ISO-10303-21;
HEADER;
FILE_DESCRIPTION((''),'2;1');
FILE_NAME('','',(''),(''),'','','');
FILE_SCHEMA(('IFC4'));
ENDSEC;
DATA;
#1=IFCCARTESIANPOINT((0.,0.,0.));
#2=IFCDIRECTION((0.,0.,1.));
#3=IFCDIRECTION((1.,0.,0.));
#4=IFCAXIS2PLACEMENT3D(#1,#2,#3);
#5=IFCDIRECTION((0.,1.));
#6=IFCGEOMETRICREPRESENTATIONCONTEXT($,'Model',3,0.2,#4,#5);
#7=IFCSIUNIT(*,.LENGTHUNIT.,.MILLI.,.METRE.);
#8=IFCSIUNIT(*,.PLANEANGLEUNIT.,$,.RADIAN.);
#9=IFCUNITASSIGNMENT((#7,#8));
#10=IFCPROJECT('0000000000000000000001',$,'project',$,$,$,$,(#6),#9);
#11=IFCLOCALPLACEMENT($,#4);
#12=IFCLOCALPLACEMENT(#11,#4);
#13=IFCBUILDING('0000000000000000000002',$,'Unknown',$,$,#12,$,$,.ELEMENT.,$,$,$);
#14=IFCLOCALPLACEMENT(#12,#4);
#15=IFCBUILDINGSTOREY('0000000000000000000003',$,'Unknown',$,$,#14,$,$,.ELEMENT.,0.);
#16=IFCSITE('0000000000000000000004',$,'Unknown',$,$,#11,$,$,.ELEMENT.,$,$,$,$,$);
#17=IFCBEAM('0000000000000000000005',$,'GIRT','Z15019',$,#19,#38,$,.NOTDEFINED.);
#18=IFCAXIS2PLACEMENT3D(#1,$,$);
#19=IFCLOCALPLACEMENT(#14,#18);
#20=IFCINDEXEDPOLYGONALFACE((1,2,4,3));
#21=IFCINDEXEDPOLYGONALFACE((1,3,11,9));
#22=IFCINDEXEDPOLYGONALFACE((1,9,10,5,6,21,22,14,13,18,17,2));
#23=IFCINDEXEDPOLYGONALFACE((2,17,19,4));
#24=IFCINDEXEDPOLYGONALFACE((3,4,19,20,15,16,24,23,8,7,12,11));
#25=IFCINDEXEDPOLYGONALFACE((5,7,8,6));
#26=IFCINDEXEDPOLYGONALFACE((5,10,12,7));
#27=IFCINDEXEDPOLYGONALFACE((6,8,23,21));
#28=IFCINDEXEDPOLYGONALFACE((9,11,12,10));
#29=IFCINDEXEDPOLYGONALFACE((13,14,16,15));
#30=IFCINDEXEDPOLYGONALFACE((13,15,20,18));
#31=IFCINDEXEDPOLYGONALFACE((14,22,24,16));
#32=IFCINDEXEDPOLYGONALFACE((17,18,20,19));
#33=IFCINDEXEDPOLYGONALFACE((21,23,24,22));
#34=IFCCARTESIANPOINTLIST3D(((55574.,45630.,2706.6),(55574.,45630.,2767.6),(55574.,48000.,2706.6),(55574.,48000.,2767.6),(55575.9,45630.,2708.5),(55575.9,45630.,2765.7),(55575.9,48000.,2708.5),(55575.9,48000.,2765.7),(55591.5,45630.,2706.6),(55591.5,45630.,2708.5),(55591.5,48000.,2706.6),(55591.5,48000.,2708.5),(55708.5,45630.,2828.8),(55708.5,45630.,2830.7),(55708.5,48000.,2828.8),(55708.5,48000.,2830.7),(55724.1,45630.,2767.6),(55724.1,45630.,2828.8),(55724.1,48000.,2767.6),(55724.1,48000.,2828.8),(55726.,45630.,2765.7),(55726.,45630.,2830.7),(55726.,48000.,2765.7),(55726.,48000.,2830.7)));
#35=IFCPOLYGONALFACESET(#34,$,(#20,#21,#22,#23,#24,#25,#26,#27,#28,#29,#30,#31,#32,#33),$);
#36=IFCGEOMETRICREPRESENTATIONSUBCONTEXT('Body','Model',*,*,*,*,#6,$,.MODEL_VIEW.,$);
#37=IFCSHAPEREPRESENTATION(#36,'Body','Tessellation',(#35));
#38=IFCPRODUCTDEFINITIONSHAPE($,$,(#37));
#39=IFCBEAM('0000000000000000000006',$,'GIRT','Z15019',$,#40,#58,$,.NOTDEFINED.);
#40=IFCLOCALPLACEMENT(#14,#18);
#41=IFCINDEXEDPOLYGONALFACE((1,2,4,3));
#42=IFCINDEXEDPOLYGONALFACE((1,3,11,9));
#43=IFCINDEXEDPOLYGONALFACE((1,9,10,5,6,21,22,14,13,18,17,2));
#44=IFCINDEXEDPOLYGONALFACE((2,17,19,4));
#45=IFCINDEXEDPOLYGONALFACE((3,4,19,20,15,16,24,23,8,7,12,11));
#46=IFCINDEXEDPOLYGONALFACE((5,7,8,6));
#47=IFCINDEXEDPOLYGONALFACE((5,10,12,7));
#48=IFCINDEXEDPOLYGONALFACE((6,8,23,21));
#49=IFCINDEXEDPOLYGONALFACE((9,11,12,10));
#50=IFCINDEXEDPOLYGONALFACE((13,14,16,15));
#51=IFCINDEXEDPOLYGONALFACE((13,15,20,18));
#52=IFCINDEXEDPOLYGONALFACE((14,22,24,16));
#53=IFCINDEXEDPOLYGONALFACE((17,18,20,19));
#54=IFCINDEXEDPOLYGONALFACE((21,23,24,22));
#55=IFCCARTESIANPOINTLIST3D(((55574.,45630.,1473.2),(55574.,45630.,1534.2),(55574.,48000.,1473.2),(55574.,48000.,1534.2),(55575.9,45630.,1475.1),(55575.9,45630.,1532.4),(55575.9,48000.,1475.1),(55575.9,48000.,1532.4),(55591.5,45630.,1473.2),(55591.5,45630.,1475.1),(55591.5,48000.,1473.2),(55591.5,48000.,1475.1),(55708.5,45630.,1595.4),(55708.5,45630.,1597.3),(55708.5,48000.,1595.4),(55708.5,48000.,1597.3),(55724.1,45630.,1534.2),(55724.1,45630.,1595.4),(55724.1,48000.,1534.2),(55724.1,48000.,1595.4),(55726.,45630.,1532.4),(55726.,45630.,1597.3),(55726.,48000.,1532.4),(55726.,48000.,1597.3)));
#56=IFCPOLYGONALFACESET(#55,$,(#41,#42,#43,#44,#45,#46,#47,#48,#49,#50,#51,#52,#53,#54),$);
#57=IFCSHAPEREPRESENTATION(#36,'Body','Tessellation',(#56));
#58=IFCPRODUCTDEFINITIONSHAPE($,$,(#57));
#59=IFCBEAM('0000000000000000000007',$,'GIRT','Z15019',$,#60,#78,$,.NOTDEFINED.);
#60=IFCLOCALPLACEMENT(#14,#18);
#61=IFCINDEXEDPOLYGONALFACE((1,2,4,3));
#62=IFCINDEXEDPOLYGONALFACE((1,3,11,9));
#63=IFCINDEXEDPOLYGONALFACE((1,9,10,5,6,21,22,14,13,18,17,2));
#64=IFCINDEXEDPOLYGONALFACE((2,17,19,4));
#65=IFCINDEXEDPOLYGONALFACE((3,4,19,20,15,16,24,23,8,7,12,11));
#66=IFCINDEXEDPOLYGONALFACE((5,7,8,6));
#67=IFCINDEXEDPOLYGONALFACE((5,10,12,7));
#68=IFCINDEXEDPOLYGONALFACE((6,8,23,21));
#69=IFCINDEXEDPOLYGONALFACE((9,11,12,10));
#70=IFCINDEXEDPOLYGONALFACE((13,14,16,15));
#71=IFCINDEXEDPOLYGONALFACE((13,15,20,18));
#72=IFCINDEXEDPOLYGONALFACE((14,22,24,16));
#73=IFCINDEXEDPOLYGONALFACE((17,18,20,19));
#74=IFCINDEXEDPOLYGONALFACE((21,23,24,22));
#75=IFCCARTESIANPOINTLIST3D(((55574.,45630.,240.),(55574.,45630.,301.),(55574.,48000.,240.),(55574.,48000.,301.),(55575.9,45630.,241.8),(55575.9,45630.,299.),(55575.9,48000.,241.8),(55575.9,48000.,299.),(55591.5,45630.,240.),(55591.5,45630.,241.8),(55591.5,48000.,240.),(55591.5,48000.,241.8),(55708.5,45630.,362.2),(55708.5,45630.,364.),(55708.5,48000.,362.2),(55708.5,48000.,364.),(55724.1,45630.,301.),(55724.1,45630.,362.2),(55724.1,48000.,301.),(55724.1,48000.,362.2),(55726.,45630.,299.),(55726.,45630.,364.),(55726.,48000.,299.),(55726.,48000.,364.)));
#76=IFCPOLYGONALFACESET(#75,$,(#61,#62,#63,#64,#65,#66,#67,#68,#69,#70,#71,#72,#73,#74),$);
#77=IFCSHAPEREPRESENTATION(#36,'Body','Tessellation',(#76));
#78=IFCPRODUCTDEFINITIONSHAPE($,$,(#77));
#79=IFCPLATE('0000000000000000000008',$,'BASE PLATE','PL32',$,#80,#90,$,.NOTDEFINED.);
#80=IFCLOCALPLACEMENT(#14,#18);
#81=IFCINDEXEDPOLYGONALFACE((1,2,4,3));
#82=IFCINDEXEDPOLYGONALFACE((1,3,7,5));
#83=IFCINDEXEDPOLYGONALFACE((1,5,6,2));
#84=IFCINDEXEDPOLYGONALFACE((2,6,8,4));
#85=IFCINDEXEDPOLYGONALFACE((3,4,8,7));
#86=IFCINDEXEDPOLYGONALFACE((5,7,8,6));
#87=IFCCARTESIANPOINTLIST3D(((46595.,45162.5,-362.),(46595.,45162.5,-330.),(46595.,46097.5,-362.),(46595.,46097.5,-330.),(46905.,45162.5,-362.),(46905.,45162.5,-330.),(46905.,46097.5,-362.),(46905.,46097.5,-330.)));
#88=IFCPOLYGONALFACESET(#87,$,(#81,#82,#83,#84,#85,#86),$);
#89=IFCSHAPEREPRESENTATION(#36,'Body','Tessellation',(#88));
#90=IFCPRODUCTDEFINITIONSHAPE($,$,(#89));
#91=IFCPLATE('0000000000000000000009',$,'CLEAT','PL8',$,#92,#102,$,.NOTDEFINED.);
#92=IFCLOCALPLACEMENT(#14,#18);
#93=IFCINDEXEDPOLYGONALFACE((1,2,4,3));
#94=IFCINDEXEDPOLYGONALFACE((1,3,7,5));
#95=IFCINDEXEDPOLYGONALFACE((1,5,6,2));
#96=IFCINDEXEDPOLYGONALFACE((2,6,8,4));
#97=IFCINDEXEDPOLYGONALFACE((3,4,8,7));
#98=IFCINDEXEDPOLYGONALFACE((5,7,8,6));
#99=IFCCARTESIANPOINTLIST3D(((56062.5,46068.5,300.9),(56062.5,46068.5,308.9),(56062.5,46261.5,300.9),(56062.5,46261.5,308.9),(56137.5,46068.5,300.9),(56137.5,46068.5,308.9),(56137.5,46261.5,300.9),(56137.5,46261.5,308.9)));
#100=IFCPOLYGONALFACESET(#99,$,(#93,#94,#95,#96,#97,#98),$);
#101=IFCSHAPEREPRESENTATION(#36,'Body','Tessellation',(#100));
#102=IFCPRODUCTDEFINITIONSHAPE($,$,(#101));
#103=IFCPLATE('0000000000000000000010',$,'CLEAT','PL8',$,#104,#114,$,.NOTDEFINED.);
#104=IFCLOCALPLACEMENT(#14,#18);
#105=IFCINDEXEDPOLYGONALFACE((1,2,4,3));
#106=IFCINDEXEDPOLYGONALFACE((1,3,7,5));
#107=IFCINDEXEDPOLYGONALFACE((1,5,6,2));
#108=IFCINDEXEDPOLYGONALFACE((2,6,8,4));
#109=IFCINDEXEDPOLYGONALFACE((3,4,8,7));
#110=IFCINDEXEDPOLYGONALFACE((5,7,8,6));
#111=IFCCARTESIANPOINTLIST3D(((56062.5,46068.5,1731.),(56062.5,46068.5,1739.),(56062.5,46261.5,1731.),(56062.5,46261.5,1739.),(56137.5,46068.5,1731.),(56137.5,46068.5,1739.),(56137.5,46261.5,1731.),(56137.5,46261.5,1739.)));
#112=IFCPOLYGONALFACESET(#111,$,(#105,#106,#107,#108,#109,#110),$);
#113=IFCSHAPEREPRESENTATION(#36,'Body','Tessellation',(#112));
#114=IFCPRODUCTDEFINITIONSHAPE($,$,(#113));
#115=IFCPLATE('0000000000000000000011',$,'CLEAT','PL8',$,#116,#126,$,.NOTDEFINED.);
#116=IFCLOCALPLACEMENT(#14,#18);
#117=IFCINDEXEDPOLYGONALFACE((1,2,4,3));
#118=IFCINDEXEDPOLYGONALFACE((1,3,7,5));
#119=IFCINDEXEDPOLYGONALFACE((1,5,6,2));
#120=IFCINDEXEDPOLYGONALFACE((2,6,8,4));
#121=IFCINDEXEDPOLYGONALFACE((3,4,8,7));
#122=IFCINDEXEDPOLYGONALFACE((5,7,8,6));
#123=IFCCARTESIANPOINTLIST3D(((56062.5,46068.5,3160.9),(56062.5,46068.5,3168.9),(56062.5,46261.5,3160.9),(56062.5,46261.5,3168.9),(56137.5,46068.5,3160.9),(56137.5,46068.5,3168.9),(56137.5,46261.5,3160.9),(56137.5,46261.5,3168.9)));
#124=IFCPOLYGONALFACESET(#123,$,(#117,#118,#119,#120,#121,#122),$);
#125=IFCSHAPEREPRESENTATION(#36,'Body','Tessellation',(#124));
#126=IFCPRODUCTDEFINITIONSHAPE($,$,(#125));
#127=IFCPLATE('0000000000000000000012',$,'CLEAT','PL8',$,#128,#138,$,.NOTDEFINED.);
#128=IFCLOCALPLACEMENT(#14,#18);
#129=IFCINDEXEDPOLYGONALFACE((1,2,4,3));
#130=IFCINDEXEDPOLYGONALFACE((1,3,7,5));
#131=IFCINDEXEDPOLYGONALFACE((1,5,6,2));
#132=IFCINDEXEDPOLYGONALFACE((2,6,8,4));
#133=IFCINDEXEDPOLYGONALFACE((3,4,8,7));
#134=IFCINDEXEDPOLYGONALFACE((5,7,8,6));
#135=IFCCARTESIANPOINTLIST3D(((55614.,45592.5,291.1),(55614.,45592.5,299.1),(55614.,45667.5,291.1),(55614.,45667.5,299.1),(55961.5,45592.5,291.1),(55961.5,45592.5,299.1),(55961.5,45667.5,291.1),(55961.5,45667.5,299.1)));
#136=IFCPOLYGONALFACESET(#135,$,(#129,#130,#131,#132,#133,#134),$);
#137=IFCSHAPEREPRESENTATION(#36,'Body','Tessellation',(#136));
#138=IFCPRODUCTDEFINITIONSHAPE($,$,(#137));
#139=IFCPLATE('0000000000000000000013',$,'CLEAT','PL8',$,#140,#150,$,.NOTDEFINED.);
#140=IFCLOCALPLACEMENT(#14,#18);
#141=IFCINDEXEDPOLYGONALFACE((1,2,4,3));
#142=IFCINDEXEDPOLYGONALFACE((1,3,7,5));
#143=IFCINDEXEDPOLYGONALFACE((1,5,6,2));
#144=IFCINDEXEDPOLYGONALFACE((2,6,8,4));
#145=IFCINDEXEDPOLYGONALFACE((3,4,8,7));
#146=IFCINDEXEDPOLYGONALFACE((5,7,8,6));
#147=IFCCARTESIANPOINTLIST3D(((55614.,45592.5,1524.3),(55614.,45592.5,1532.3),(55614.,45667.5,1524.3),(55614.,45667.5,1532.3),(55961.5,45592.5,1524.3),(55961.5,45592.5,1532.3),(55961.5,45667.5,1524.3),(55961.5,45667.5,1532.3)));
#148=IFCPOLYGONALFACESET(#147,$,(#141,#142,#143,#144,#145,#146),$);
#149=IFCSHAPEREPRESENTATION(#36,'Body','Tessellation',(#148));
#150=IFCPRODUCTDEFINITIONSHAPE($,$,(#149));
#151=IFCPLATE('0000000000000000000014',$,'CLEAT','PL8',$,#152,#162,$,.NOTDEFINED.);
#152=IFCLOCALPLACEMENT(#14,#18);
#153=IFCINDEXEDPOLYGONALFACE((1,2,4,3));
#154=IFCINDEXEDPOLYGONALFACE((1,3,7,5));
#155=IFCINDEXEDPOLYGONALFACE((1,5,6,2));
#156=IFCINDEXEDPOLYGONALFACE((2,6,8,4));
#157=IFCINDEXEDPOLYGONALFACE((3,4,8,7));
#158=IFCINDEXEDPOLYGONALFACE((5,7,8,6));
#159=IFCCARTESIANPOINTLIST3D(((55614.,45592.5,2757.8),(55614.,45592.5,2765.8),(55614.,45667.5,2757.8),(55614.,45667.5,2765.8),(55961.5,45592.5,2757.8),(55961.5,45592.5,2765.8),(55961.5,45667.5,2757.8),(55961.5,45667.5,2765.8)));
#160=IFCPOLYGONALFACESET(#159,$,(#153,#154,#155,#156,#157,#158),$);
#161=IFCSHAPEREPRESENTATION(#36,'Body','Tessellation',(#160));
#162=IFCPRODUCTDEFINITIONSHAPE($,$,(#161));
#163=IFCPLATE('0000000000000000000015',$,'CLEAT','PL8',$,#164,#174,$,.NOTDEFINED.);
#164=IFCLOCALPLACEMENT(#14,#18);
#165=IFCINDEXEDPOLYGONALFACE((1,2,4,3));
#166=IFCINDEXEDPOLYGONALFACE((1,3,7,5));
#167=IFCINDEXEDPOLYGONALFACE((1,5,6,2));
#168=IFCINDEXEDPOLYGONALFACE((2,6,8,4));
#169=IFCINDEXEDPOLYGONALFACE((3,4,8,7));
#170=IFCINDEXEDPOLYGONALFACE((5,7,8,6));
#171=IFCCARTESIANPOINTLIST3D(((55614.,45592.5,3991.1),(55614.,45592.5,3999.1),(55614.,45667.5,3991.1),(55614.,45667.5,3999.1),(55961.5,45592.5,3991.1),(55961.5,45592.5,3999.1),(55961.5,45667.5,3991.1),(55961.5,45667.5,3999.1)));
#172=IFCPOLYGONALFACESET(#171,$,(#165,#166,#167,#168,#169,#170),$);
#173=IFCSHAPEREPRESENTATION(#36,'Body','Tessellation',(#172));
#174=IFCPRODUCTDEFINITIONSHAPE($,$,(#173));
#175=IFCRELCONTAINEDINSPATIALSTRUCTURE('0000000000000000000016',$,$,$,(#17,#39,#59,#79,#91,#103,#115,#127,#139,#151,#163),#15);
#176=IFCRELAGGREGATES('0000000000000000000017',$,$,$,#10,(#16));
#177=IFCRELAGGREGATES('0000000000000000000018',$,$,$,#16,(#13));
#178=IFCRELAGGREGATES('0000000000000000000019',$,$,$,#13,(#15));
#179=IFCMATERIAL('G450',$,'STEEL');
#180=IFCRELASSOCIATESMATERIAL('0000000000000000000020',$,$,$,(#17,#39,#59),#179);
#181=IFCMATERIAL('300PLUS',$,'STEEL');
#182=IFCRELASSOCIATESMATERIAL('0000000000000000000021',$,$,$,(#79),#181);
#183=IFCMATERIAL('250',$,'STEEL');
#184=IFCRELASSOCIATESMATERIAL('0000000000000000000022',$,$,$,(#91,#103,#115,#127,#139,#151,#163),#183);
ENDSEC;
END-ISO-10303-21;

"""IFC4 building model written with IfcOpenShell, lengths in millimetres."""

from ifc_helpers import new_model, si_unit, direction, frame, origin_with_axes, place, context, subcontext, project, spatial, line, indexed_curve, outline, extrude, material, element, save


model = new_model("IFC4")

# Units and contexts
model_context = context("Model", 3, precision=0.2, world=origin_with_axes(), true_north=direction((0.0, 1.0)))
body_context = subcontext(model_context, "Body", "Model", "MODEL_VIEW")
ifc_project = project(units=[si_unit("LENGTHUNIT", "METRE", prefix="MILLI"), si_unit("PLANEANGLEUNIT", "RADIAN")], contexts=[model_context])

# Site, building, storey
site_placement = place(None, origin_with_axes())
site = spatial("IfcSite", under=ifc_project, at=site_placement, Name="Unknown", CompositionType="ELEMENT")
building_placement = place(site_placement, origin_with_axes())
building = spatial("IfcBuilding", under=site, at=building_placement, Name="Unknown", CompositionType="ELEMENT")
storey_placement = place(building_placement, origin_with_axes())
storey = spatial("IfcBuildingStorey", under=building, at=storey_placement, Name="Unknown", CompositionType="ELEMENT", Elevation=0.0)

# Shared definitions
ifc_material_1 = material(Name="G450", Category="STEEL")
ifc_material_2 = material(Name="300PLUS", Category="STEEL")

# Beams
for number, where, z_axis, x_axis, name in (
    (1, (55650.0, 45630.0, 2766.7), (0.0, 0.0, -1.0), (0.0, 1.0, 0.0), "GIRT"),
    (2, (55650.0, 45630.0, 1533.3), (0.0, 0.0, -1.0), (0.0, 1.0, 0.0), "GIRT"),
    (3, (55650.0, 45630.0, 300.0), (0.0, 0.0, -1.0), (0.0, 1.0, 0.0), "GIRT"),
):
    element("IfcBeam", number, at=place(storey_placement, frame(where, z_axis=z_axis, x_axis=x_axis)), inside=storey, material=ifc_material_1, Name=name, Description="Z15019", PredefinedType="NOTDEFINED", context=body_context, shape_type="SolidModel", body=[
        extrude(outline(indexed_curve([(60.0, -76.0), (60.0, -58.5), (58.1, -58.5), (58.1, -74.1), (0.9, -74.1), (0.9, 76.0), (-64.0, 76.0), (-64.0, 58.5), (-62.1, 58.5), (-62.1, 74.1), (-0.9, 74.1), (-0.9, -76.0)], segments=[line(1, 2, 3, 4, 5, 6, 7, 8, 9, 10, 11, 12, 1)])), frame((0.0, 0.0, 0.0), z_axis=(-1.0, 0.0, 0.0), x_axis=(0.0, 0.0, 1.0)), (0.0, 0.0, -1.0), 2370.0),
    ])

# Plates
plate_placement = place(storey_placement, frame((46905.0, 45162.5, -346.0), z_axis=(0.0, 0.0, 1.0), x_axis=(0.0, 1.0, 0.0)))
element("IfcPlate", 4, at=plate_placement, inside=storey, material=ifc_material_2, Name="BASE PLATE", Description="PL32", PredefinedType="NOTDEFINED", context=body_context, shape_type="SolidModel", body=[
    extrude(outline(indexed_curve([(0.0, 0.0), (935.0, 0.0), (935.0, 310.0), (0.0, 310.0)], segments=[line(1, 2, 3, 4, 1)])), frame((0.0, 0.0, 16.0), z_axis=(0.0, 0.0, 1.0), x_axis=(1.0, 0.0, 0.0)), (0.0, 0.0, -1.0), 32.0),
])
ifc_material_3 = material(Name="250", Category="STEEL")
for number, where, z_axis, x_axis, name in (
    (5, (56062.5, 46068.5, 304.9), (0.0, 0.0, 1.0), (1.0, 0.0, 0.0), "CLEAT"),
    (6, (56062.5, 46068.5, 1735.0), (0.0, 0.0, 1.0), (1.0, 0.0, 0.0), "CLEAT"),
    (7, (56062.5, 46068.5, 3164.9), (0.0, 0.0, 1.0), (1.0, 0.0, 0.0), "CLEAT"),
):
    element("IfcPlate", number, at=place(storey_placement, frame(where, z_axis=z_axis, x_axis=x_axis)), inside=storey, material=ifc_material_3, Name=name, Description="PL8", PredefinedType="NOTDEFINED", context=body_context, shape_type="SolidModel", body=[
        extrude(outline(indexed_curve([(0.0, 0.0), (75.0, 0.0), (75.0, 193.0), (0.0, 193.0)], segments=[line(1, 2, 3, 4, 1)])), frame((0.0, 0.0, 4.0), z_axis=(0.0, 0.0, 1.0), x_axis=(1.0, 0.0, 0.0)), (0.0, 0.0, -1.0), 8.0),
    ])
for number, where, z_axis, x_axis, name in (
    (8, (55961.5, 45592.5, 295.1), (0.0, 0.0, 1.0), (0.0, 1.0, 0.0), "CLEAT"),
    (9, (55961.5, 45592.5, 1528.3), (0.0, 0.0, 1.0), (0.0, 1.0, 0.0), "CLEAT"),
    (10, (55961.5, 45592.5, 2761.8), (0.0, 0.0, 1.0), (0.0, 1.0, 0.0), "CLEAT"),
    (11, (55961.5, 45592.5, 3995.1), (0.0, 0.0, 1.0), (0.0, 1.0, 0.0), "CLEAT"),
):
    element("IfcPlate", number, at=place(storey_placement, frame(where, z_axis=z_axis, x_axis=x_axis)), inside=storey, material=ifc_material_3, Name=name, Description="PL8", PredefinedType="NOTDEFINED", context=body_context, shape_type="SolidModel", body=[
        extrude(outline(indexed_curve([(0.0, 0.0), (75.0, 0.0), (75.0, 347.5), (0.0, 347.5)], segments=[line(1, 2, 3, 4, 1)])), frame((0.0, 0.0, 4.0), z_axis=(0.0, 0.0, 1.0), x_axis=(1.0, 0.0, 0.0)), (0.0, 0.0, -1.0), 8.0),
    ])

save(model, "model.ifc")
